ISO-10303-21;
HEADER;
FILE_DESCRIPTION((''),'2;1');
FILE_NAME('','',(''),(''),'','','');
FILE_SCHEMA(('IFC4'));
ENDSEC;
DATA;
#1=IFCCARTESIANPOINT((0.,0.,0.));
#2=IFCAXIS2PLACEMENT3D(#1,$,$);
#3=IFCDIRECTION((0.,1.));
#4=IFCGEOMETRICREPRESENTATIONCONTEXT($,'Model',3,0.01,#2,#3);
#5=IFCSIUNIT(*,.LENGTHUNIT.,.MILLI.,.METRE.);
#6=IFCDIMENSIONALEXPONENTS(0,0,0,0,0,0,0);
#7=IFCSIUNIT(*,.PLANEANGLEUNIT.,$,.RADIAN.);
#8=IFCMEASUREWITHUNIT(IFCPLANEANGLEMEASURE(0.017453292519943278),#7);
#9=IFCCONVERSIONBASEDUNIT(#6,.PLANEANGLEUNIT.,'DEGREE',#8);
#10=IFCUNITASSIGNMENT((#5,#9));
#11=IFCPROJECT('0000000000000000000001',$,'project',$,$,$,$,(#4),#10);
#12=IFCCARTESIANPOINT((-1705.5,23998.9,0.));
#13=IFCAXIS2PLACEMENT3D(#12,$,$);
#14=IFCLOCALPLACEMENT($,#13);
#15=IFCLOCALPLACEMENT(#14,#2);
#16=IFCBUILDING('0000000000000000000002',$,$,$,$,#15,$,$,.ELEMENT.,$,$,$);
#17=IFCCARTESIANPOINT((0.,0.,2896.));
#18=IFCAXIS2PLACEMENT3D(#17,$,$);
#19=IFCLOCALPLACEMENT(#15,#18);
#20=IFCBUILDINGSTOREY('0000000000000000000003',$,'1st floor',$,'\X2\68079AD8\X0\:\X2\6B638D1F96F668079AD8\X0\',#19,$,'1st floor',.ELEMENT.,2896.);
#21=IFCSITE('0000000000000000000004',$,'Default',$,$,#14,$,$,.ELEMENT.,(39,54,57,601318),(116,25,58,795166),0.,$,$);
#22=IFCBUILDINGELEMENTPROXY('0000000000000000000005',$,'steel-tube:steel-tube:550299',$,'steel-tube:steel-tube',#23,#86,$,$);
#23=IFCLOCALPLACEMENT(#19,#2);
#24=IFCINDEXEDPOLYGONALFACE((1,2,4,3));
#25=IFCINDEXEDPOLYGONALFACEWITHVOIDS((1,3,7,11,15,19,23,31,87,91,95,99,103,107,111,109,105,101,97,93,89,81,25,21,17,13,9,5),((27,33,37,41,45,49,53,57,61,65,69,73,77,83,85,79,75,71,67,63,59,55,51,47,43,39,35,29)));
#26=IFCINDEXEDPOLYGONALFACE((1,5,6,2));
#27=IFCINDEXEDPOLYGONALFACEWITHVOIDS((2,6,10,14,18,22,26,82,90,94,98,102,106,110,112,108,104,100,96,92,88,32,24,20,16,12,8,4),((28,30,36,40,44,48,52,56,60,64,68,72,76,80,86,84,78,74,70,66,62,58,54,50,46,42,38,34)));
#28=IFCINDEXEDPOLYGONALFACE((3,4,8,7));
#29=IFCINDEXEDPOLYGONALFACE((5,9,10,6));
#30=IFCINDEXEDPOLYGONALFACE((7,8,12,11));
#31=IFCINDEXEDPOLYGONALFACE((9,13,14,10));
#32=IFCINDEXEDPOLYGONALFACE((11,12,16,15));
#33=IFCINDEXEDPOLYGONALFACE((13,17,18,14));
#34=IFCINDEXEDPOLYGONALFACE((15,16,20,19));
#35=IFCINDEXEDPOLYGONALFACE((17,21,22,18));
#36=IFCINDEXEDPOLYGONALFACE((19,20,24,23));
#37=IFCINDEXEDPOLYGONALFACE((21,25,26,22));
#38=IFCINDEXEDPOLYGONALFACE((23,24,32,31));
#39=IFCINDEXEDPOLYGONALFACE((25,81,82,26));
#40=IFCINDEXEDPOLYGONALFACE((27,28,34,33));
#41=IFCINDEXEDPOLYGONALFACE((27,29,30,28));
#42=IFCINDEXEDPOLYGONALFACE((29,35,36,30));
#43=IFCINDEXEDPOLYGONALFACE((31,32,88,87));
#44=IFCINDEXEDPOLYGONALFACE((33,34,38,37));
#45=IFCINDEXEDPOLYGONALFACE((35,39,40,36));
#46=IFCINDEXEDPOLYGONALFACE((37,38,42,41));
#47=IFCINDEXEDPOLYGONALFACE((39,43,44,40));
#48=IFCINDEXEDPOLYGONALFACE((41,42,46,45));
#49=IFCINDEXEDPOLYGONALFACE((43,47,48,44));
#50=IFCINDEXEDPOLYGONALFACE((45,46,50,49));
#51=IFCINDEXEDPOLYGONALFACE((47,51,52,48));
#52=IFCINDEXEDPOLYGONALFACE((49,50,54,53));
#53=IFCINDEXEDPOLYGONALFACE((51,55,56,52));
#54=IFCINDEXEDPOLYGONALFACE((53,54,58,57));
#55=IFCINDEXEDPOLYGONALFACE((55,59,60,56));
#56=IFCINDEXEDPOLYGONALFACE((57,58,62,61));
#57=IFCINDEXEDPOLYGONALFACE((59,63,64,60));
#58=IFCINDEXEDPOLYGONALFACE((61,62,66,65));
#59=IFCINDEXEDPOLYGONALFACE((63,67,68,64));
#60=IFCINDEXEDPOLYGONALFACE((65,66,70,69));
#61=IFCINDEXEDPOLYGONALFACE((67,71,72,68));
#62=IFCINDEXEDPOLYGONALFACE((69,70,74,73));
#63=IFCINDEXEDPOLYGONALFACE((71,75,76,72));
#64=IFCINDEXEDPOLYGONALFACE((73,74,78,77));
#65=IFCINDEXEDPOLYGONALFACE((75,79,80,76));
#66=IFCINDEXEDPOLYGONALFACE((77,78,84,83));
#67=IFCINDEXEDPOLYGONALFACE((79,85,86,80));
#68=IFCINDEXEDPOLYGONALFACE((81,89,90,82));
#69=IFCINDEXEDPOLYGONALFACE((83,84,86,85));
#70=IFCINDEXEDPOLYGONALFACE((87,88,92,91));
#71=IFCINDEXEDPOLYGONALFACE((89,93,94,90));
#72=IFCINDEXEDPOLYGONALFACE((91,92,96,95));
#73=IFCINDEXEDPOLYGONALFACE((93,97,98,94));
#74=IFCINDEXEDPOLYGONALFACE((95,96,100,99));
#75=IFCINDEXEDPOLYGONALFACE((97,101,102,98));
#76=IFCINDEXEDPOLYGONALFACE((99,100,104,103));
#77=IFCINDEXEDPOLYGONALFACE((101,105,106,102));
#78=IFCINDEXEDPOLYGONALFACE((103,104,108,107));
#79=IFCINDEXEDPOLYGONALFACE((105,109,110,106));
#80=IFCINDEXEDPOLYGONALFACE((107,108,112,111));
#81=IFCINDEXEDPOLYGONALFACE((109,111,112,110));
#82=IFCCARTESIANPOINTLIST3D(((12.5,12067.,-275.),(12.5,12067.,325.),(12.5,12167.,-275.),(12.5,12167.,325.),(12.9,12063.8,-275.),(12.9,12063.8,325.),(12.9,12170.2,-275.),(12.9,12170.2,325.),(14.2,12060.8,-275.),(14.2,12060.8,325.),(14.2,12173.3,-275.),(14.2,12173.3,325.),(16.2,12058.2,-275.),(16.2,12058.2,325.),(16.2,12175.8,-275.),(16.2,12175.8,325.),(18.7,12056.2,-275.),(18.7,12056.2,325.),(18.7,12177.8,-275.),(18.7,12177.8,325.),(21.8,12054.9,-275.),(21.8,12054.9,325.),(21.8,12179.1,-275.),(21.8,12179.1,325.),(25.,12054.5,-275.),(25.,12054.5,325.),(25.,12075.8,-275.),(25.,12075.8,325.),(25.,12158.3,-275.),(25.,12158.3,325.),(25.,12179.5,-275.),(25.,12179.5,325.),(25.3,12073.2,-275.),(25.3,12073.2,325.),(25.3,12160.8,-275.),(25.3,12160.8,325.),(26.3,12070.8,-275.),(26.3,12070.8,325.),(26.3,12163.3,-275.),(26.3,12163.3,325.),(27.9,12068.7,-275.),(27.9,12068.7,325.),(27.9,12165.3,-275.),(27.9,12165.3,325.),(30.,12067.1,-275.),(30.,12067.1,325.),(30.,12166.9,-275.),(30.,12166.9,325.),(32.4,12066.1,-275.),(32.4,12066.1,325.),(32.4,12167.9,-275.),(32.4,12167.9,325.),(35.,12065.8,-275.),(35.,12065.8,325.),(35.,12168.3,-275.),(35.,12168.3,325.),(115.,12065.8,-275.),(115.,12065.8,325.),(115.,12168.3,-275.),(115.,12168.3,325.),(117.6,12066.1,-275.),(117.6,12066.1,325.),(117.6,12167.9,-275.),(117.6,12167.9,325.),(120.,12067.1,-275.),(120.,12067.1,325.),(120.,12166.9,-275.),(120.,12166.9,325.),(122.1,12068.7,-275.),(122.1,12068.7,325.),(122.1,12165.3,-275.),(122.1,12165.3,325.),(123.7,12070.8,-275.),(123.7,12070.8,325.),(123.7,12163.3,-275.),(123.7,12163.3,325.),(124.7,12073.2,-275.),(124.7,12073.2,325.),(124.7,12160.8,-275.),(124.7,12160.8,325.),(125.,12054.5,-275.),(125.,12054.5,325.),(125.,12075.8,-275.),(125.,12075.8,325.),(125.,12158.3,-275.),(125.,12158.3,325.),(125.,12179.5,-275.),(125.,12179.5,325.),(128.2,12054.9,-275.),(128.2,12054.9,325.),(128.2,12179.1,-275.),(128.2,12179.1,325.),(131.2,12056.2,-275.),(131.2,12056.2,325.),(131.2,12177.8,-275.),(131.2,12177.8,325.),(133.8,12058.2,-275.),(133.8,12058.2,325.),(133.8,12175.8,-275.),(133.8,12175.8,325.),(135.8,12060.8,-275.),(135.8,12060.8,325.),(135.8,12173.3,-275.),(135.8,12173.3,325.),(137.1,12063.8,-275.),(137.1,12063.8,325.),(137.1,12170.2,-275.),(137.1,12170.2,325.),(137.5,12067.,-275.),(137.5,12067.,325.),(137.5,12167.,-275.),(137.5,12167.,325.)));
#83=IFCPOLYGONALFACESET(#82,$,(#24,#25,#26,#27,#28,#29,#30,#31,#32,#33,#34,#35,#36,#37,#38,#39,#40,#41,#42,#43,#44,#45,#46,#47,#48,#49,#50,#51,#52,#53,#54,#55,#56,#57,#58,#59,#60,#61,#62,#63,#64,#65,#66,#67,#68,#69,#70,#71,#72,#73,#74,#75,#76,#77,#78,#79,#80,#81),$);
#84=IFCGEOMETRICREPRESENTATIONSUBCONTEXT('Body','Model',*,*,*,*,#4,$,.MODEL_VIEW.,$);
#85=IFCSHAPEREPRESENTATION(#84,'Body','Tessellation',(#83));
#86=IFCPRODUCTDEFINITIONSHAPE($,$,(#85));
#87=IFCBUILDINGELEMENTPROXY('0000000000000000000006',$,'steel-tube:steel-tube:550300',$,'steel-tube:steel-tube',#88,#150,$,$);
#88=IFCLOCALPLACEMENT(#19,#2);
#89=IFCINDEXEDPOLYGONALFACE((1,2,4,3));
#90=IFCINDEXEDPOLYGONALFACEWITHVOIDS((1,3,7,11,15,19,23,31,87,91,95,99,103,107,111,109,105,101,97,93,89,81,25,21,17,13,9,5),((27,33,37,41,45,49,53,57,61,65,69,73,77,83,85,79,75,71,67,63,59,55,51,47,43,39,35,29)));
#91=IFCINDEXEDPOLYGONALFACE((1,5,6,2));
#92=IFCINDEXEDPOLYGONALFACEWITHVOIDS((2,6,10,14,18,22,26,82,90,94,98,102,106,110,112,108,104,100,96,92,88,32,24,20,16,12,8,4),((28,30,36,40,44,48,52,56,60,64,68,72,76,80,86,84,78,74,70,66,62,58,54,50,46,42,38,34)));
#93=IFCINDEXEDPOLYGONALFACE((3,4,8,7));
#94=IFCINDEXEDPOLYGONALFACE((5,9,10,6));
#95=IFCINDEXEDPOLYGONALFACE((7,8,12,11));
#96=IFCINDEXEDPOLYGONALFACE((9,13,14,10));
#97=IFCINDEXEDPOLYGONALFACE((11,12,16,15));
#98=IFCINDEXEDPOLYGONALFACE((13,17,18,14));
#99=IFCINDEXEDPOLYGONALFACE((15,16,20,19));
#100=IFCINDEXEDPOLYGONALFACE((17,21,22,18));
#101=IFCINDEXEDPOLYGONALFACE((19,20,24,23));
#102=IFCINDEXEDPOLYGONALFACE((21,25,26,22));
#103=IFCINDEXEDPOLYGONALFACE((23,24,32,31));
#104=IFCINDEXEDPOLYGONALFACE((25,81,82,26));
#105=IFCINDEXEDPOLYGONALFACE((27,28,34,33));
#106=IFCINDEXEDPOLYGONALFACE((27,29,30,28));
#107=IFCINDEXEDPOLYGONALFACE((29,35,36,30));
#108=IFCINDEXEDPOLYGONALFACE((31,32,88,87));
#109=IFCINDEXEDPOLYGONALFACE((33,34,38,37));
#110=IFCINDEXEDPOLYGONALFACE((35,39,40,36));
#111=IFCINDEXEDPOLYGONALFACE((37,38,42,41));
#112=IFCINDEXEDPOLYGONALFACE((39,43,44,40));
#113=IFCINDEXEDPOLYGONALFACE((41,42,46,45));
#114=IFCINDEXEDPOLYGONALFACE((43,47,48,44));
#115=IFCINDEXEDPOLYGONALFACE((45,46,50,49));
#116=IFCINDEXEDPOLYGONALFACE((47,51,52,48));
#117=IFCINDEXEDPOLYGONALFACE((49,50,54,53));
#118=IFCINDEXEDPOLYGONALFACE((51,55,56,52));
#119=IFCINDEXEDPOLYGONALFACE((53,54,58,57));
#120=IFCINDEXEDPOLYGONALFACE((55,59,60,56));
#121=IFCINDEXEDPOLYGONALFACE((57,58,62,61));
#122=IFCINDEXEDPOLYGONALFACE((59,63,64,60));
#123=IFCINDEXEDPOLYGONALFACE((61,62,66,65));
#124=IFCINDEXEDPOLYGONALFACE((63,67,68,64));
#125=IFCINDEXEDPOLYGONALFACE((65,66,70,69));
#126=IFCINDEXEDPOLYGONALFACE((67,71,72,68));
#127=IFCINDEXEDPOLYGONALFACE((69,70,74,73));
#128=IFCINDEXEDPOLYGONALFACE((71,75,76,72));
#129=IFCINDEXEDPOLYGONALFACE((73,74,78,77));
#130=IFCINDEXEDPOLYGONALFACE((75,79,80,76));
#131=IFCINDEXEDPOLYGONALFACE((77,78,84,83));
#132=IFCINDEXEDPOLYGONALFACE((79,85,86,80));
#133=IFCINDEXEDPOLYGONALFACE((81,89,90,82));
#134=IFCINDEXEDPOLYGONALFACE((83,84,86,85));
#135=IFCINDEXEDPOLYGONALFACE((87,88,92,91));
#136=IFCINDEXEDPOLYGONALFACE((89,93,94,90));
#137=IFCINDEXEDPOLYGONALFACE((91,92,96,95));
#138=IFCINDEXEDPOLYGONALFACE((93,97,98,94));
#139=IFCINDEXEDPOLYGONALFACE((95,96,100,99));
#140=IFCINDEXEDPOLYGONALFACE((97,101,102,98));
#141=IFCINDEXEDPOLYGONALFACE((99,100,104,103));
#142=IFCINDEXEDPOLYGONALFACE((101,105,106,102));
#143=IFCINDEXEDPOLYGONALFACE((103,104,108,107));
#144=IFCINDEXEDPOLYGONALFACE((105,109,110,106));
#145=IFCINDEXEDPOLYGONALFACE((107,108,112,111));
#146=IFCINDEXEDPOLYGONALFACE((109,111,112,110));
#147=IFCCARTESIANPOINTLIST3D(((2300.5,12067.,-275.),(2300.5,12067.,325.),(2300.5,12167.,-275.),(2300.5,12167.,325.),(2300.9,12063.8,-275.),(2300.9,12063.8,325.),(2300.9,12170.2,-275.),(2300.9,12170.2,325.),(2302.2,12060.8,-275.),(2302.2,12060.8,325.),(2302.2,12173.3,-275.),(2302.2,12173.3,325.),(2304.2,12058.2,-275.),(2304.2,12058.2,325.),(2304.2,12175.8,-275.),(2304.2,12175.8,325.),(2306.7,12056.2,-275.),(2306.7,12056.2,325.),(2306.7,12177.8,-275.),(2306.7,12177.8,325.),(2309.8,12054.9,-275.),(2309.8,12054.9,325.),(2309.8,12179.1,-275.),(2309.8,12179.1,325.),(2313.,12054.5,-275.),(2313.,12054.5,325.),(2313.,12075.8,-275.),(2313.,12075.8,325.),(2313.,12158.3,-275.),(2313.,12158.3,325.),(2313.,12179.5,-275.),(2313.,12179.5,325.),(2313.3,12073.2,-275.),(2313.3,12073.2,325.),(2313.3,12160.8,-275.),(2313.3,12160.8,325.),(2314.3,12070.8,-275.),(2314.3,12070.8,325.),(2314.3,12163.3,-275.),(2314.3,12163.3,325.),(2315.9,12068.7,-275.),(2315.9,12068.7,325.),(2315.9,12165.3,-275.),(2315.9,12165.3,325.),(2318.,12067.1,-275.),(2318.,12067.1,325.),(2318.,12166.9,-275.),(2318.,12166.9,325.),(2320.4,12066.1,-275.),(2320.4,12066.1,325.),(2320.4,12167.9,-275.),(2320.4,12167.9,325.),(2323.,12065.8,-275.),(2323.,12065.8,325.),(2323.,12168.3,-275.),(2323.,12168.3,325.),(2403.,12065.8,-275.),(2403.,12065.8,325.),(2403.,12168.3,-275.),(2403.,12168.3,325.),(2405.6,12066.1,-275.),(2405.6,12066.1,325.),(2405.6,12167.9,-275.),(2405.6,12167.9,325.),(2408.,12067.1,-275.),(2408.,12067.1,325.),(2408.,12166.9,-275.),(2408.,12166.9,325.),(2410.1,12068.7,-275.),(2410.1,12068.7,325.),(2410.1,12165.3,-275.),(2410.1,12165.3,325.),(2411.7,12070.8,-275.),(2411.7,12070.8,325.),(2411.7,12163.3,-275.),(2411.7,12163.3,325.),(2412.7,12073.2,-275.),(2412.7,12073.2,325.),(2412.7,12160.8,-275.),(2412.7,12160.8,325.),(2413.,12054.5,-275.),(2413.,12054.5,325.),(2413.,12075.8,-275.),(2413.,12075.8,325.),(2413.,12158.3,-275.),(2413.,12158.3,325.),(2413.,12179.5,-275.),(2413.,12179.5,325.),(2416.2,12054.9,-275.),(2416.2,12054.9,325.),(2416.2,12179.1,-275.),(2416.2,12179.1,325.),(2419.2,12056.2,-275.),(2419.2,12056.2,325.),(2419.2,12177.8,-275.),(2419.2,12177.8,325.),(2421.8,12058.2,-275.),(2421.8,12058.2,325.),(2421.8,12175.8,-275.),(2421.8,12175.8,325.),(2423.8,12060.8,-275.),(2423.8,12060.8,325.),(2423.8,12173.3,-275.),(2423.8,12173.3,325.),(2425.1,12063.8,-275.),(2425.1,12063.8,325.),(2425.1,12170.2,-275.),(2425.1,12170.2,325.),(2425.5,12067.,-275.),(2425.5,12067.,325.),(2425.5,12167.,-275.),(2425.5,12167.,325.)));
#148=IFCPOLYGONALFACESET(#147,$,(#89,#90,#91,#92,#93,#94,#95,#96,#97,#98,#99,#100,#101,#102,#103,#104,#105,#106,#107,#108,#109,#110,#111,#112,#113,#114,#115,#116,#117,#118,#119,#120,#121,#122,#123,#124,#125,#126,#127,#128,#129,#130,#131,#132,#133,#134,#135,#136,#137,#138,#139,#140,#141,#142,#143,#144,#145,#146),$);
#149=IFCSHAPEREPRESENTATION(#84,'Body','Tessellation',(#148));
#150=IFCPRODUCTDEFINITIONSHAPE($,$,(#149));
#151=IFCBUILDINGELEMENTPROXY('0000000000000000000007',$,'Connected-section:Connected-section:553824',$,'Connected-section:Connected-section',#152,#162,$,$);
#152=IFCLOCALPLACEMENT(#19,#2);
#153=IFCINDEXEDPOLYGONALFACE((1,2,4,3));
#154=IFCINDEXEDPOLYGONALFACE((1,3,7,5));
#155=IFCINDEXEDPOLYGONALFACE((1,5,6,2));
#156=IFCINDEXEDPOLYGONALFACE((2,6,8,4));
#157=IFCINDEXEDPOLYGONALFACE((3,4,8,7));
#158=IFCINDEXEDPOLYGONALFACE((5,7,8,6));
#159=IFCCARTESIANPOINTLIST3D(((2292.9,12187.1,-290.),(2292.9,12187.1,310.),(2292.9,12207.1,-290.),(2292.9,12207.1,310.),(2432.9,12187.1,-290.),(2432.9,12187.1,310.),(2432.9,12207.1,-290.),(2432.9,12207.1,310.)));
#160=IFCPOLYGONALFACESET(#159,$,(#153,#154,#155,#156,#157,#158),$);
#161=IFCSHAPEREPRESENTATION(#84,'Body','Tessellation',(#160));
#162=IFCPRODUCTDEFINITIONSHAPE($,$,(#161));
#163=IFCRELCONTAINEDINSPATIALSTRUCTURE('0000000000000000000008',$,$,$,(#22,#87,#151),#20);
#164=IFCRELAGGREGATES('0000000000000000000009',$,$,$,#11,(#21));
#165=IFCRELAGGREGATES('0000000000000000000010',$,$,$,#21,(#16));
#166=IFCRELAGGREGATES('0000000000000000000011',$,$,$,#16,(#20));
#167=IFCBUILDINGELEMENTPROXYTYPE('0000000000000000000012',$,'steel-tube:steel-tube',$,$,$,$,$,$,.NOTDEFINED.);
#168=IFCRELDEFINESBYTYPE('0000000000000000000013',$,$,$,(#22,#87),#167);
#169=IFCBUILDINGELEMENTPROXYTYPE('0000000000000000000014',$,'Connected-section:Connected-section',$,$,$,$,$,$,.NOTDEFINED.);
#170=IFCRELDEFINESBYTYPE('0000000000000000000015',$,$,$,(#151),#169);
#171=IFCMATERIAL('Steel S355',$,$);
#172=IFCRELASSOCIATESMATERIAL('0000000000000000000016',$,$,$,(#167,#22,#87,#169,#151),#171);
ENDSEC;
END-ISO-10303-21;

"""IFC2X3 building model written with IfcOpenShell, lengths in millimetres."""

from ifc_helpers import new_model, entity, si_unit, converted_unit, direction, frame, frame_2d, origin, place, context, subcontext, project, spatial, polyline, circle_curve, parameter, trimmed, segment, composite_curve, rectangle, outline, extrude, source, transform, mapped, material, type_object, type_shapes, element, save


model = new_model("IFC2X3")

# Units and contexts
model_context = context("Model", 3, precision=0.01, world=origin(), true_north=direction((0.0, 1.0)))
body_context = subcontext(model_context, "Body", "Model", "MODEL_VIEW")
ifc_project = project(units=[si_unit("LENGTHUNIT", "METRE", prefix="MILLI"), converted_unit("PLANEANGLEUNIT", "DEGREE", entity("IfcPlaneAngleMeasure", 0.017453292519943278), si_unit("PLANEANGLEUNIT", "RADIAN"), dimensions=[0, 0, 0, 0, 0, 0, 0])], contexts=[model_context])

# Site, building, storey
site_placement = place(None, frame((-1705.5, 23998.9, 0.0)))
site = spatial("IfcSite", under=ifc_project, at=site_placement, Name="Default", CompositionType="ELEMENT", RefLatitude=(39, 54, 57, 601318), RefLongitude=(116, 25, 58, 795166), RefElevation=0.0)
building_placement = place(site_placement, origin())
building = spatial("IfcBuilding", under=site, at=building_placement, CompositionType="ELEMENT")
storey_placement = place(building_placement, frame((0.0, 0.0, 2896.0)))
storey = spatial("IfcBuildingStorey", under=building, at=storey_placement, Name="1st floor", ObjectType="标高:正负零标高", LongName="1st floor", CompositionType="ELEMENT", Elevation=2896.0)

# Shared definitions
ifc_material_1 = material(Name="Steel S355")

# Building element proxies
building_element_proxy_type_1 = type_object("IfcBuildingElementProxyType", Name="steel-tube:steel-tube", PredefinedType="NOTDEFINED", material=ifc_material_1)
shared_shape_1 = source(origin(), body_context, "Body", "SweptSolid", [
    extrude(outline(composite_curve([segment(trimmed(circle_curve(frame_2d((50.0, -50.0), x_axis=(1.0, 0.0)), 12.5), [parameter(270.0)], [parameter(0.0)], True, "PARAMETER"), True, "CONTINUOUS"), segment(polyline([(62.5, -50.0), (62.5, 50.0)]), True, "CONTINUOUS"), segment(trimmed(circle_curve(frame_2d((50.0, 50.0), x_axis=(1.0, 0.0)), 12.5), [parameter(0.0)], [parameter(90.0)], True, "PARAMETER"), True, "CONTINUOUS"), segment(polyline([(50.0, 62.5), (-50.0, 62.5)]), True, "CONTINUOUS"), segment(trimmed(circle_curve(frame_2d((-50.0, 50.0), x_axis=(1.0, 0.0)), 12.5), [parameter(90.0)], [parameter(180.0)], True, "PARAMETER"), True, "CONTINUOUS"), segment(polyline([(-62.5, 50.0), (-62.5, -50.0)]), True, "CONTINUOUS"), segment(trimmed(circle_curve(frame_2d((-50.0, -50.0), x_axis=(1.0, 0.0)), 12.5), [parameter(180.0)], [parameter(270.0)], True, "PARAMETER"), True, "CONTINUOUS"), segment(polyline([(-50.0, -62.5), (50.0, -62.5)]), True, "CONTINUOUS")], self_intersect=False), holes=[composite_curve([segment(trimmed(circle_curve(frame_2d((-41.2, 40.0), x_axis=(1.0, 0.0)), 10.0), [parameter(90.0)], [parameter(180.0)], True, "PARAMETER"), False, "CONTINUOUS"), segment(polyline([(-41.3, 50.0), (41.2, 50.0)]), True, "CONTINUOUS"), segment(trimmed(circle_curve(frame_2d((41.2, 40.0), x_axis=(1.0, 0.0)), 10.0), [parameter(0.0)], [parameter(90.0)], True, "PARAMETER"), False, "CONTINUOUS"), segment(polyline([(51.2, 40.0), (51.2, -40.0)]), True, "CONTINUOUS"), segment(trimmed(circle_curve(frame_2d((41.2, -40.0), x_axis=(1.0, 0.0)), 10.0), [parameter(270.0)], [parameter(360.0)], True, "PARAMETER"), False, "CONTINUOUS"), segment(polyline([(41.2, -50.0), (-41.3, -50.0)]), True, "CONTINUOUS"), segment(trimmed(circle_curve(frame_2d((-41.3, -40.0), x_axis=(1.0, 0.0)), 10.0), [parameter(180.0)], [parameter(270.0)], True, "PARAMETER"), False, "CONTINUOUS"), segment(polyline([(-51.3, -40.0), (-51.3, 40.0)]), True, "CONTINUOUS")], self_intersect=False)]), frame((62.5, 62.5, -175.0)), (0.0, 0.0, 1.0), 600.0),
])
type_shapes(building_element_proxy_type_1, [shared_shape_1])
for number, where, z_axis, x_axis, name in (
    (1, (12.5, 12179.5, -100.0), (0.0, 0.0, 1.0), (0.0, -1.0, 0.0), "steel-tube:steel-tube:550299"),
    (2, (2300.5, 12179.5, -100.0), (0.0, 0.0, 1.0), (0.0, -1.0, 0.0), "steel-tube:steel-tube:550300"),
):
    element("IfcBuildingElementProxy", number, at=place(storey_placement, frame(where, z_axis=z_axis, x_axis=x_axis)), inside=storey, type_object=building_element_proxy_type_1, material=ifc_material_1, Name=name, ObjectType="steel-tube:steel-tube", context=body_context, shape_type="MappedRepresentation", body=[
        mapped(shared_shape_1, transform((0.0, 0.0, 0.0), scale=1.0)),
    ])
building_element_proxy_type_2 = type_object("IfcBuildingElementProxyType", Name="Connected-section:Connected-section", PredefinedType="NOTDEFINED", material=ifc_material_1)
shared_shape_2 = source(origin(), body_context, "Body", "SweptSolid", [
    extrude(rectangle(XDim=20.0, YDim=140.0, at=frame_2d((0.0, 0.0), x_axis=(1.0, 0.0))), frame((70.0, 10.0, 0.0), z_axis=(0.0, 0.0, 1.0), x_axis=(0.0, 1.0, 0.0)), (0.0, 0.0, 1.0), 600.0),
])
type_shapes(building_element_proxy_type_2, [shared_shape_2])
proxy_placement = place(storey_placement, frame((2292.9, 12187.1, -290.0)))
element("IfcBuildingElementProxy", 3, at=proxy_placement, inside=storey, type_object=building_element_proxy_type_2, material=ifc_material_1, Name="Connected-section:Connected-section:553824", ObjectType="Connected-section:Connected-section", context=body_context, shape_type="MappedRepresentation", body=[
    mapped(shared_shape_2, transform((0.0, 0.0, 0.0), scale=1.0)),
])

save(model, "model.ifc")
